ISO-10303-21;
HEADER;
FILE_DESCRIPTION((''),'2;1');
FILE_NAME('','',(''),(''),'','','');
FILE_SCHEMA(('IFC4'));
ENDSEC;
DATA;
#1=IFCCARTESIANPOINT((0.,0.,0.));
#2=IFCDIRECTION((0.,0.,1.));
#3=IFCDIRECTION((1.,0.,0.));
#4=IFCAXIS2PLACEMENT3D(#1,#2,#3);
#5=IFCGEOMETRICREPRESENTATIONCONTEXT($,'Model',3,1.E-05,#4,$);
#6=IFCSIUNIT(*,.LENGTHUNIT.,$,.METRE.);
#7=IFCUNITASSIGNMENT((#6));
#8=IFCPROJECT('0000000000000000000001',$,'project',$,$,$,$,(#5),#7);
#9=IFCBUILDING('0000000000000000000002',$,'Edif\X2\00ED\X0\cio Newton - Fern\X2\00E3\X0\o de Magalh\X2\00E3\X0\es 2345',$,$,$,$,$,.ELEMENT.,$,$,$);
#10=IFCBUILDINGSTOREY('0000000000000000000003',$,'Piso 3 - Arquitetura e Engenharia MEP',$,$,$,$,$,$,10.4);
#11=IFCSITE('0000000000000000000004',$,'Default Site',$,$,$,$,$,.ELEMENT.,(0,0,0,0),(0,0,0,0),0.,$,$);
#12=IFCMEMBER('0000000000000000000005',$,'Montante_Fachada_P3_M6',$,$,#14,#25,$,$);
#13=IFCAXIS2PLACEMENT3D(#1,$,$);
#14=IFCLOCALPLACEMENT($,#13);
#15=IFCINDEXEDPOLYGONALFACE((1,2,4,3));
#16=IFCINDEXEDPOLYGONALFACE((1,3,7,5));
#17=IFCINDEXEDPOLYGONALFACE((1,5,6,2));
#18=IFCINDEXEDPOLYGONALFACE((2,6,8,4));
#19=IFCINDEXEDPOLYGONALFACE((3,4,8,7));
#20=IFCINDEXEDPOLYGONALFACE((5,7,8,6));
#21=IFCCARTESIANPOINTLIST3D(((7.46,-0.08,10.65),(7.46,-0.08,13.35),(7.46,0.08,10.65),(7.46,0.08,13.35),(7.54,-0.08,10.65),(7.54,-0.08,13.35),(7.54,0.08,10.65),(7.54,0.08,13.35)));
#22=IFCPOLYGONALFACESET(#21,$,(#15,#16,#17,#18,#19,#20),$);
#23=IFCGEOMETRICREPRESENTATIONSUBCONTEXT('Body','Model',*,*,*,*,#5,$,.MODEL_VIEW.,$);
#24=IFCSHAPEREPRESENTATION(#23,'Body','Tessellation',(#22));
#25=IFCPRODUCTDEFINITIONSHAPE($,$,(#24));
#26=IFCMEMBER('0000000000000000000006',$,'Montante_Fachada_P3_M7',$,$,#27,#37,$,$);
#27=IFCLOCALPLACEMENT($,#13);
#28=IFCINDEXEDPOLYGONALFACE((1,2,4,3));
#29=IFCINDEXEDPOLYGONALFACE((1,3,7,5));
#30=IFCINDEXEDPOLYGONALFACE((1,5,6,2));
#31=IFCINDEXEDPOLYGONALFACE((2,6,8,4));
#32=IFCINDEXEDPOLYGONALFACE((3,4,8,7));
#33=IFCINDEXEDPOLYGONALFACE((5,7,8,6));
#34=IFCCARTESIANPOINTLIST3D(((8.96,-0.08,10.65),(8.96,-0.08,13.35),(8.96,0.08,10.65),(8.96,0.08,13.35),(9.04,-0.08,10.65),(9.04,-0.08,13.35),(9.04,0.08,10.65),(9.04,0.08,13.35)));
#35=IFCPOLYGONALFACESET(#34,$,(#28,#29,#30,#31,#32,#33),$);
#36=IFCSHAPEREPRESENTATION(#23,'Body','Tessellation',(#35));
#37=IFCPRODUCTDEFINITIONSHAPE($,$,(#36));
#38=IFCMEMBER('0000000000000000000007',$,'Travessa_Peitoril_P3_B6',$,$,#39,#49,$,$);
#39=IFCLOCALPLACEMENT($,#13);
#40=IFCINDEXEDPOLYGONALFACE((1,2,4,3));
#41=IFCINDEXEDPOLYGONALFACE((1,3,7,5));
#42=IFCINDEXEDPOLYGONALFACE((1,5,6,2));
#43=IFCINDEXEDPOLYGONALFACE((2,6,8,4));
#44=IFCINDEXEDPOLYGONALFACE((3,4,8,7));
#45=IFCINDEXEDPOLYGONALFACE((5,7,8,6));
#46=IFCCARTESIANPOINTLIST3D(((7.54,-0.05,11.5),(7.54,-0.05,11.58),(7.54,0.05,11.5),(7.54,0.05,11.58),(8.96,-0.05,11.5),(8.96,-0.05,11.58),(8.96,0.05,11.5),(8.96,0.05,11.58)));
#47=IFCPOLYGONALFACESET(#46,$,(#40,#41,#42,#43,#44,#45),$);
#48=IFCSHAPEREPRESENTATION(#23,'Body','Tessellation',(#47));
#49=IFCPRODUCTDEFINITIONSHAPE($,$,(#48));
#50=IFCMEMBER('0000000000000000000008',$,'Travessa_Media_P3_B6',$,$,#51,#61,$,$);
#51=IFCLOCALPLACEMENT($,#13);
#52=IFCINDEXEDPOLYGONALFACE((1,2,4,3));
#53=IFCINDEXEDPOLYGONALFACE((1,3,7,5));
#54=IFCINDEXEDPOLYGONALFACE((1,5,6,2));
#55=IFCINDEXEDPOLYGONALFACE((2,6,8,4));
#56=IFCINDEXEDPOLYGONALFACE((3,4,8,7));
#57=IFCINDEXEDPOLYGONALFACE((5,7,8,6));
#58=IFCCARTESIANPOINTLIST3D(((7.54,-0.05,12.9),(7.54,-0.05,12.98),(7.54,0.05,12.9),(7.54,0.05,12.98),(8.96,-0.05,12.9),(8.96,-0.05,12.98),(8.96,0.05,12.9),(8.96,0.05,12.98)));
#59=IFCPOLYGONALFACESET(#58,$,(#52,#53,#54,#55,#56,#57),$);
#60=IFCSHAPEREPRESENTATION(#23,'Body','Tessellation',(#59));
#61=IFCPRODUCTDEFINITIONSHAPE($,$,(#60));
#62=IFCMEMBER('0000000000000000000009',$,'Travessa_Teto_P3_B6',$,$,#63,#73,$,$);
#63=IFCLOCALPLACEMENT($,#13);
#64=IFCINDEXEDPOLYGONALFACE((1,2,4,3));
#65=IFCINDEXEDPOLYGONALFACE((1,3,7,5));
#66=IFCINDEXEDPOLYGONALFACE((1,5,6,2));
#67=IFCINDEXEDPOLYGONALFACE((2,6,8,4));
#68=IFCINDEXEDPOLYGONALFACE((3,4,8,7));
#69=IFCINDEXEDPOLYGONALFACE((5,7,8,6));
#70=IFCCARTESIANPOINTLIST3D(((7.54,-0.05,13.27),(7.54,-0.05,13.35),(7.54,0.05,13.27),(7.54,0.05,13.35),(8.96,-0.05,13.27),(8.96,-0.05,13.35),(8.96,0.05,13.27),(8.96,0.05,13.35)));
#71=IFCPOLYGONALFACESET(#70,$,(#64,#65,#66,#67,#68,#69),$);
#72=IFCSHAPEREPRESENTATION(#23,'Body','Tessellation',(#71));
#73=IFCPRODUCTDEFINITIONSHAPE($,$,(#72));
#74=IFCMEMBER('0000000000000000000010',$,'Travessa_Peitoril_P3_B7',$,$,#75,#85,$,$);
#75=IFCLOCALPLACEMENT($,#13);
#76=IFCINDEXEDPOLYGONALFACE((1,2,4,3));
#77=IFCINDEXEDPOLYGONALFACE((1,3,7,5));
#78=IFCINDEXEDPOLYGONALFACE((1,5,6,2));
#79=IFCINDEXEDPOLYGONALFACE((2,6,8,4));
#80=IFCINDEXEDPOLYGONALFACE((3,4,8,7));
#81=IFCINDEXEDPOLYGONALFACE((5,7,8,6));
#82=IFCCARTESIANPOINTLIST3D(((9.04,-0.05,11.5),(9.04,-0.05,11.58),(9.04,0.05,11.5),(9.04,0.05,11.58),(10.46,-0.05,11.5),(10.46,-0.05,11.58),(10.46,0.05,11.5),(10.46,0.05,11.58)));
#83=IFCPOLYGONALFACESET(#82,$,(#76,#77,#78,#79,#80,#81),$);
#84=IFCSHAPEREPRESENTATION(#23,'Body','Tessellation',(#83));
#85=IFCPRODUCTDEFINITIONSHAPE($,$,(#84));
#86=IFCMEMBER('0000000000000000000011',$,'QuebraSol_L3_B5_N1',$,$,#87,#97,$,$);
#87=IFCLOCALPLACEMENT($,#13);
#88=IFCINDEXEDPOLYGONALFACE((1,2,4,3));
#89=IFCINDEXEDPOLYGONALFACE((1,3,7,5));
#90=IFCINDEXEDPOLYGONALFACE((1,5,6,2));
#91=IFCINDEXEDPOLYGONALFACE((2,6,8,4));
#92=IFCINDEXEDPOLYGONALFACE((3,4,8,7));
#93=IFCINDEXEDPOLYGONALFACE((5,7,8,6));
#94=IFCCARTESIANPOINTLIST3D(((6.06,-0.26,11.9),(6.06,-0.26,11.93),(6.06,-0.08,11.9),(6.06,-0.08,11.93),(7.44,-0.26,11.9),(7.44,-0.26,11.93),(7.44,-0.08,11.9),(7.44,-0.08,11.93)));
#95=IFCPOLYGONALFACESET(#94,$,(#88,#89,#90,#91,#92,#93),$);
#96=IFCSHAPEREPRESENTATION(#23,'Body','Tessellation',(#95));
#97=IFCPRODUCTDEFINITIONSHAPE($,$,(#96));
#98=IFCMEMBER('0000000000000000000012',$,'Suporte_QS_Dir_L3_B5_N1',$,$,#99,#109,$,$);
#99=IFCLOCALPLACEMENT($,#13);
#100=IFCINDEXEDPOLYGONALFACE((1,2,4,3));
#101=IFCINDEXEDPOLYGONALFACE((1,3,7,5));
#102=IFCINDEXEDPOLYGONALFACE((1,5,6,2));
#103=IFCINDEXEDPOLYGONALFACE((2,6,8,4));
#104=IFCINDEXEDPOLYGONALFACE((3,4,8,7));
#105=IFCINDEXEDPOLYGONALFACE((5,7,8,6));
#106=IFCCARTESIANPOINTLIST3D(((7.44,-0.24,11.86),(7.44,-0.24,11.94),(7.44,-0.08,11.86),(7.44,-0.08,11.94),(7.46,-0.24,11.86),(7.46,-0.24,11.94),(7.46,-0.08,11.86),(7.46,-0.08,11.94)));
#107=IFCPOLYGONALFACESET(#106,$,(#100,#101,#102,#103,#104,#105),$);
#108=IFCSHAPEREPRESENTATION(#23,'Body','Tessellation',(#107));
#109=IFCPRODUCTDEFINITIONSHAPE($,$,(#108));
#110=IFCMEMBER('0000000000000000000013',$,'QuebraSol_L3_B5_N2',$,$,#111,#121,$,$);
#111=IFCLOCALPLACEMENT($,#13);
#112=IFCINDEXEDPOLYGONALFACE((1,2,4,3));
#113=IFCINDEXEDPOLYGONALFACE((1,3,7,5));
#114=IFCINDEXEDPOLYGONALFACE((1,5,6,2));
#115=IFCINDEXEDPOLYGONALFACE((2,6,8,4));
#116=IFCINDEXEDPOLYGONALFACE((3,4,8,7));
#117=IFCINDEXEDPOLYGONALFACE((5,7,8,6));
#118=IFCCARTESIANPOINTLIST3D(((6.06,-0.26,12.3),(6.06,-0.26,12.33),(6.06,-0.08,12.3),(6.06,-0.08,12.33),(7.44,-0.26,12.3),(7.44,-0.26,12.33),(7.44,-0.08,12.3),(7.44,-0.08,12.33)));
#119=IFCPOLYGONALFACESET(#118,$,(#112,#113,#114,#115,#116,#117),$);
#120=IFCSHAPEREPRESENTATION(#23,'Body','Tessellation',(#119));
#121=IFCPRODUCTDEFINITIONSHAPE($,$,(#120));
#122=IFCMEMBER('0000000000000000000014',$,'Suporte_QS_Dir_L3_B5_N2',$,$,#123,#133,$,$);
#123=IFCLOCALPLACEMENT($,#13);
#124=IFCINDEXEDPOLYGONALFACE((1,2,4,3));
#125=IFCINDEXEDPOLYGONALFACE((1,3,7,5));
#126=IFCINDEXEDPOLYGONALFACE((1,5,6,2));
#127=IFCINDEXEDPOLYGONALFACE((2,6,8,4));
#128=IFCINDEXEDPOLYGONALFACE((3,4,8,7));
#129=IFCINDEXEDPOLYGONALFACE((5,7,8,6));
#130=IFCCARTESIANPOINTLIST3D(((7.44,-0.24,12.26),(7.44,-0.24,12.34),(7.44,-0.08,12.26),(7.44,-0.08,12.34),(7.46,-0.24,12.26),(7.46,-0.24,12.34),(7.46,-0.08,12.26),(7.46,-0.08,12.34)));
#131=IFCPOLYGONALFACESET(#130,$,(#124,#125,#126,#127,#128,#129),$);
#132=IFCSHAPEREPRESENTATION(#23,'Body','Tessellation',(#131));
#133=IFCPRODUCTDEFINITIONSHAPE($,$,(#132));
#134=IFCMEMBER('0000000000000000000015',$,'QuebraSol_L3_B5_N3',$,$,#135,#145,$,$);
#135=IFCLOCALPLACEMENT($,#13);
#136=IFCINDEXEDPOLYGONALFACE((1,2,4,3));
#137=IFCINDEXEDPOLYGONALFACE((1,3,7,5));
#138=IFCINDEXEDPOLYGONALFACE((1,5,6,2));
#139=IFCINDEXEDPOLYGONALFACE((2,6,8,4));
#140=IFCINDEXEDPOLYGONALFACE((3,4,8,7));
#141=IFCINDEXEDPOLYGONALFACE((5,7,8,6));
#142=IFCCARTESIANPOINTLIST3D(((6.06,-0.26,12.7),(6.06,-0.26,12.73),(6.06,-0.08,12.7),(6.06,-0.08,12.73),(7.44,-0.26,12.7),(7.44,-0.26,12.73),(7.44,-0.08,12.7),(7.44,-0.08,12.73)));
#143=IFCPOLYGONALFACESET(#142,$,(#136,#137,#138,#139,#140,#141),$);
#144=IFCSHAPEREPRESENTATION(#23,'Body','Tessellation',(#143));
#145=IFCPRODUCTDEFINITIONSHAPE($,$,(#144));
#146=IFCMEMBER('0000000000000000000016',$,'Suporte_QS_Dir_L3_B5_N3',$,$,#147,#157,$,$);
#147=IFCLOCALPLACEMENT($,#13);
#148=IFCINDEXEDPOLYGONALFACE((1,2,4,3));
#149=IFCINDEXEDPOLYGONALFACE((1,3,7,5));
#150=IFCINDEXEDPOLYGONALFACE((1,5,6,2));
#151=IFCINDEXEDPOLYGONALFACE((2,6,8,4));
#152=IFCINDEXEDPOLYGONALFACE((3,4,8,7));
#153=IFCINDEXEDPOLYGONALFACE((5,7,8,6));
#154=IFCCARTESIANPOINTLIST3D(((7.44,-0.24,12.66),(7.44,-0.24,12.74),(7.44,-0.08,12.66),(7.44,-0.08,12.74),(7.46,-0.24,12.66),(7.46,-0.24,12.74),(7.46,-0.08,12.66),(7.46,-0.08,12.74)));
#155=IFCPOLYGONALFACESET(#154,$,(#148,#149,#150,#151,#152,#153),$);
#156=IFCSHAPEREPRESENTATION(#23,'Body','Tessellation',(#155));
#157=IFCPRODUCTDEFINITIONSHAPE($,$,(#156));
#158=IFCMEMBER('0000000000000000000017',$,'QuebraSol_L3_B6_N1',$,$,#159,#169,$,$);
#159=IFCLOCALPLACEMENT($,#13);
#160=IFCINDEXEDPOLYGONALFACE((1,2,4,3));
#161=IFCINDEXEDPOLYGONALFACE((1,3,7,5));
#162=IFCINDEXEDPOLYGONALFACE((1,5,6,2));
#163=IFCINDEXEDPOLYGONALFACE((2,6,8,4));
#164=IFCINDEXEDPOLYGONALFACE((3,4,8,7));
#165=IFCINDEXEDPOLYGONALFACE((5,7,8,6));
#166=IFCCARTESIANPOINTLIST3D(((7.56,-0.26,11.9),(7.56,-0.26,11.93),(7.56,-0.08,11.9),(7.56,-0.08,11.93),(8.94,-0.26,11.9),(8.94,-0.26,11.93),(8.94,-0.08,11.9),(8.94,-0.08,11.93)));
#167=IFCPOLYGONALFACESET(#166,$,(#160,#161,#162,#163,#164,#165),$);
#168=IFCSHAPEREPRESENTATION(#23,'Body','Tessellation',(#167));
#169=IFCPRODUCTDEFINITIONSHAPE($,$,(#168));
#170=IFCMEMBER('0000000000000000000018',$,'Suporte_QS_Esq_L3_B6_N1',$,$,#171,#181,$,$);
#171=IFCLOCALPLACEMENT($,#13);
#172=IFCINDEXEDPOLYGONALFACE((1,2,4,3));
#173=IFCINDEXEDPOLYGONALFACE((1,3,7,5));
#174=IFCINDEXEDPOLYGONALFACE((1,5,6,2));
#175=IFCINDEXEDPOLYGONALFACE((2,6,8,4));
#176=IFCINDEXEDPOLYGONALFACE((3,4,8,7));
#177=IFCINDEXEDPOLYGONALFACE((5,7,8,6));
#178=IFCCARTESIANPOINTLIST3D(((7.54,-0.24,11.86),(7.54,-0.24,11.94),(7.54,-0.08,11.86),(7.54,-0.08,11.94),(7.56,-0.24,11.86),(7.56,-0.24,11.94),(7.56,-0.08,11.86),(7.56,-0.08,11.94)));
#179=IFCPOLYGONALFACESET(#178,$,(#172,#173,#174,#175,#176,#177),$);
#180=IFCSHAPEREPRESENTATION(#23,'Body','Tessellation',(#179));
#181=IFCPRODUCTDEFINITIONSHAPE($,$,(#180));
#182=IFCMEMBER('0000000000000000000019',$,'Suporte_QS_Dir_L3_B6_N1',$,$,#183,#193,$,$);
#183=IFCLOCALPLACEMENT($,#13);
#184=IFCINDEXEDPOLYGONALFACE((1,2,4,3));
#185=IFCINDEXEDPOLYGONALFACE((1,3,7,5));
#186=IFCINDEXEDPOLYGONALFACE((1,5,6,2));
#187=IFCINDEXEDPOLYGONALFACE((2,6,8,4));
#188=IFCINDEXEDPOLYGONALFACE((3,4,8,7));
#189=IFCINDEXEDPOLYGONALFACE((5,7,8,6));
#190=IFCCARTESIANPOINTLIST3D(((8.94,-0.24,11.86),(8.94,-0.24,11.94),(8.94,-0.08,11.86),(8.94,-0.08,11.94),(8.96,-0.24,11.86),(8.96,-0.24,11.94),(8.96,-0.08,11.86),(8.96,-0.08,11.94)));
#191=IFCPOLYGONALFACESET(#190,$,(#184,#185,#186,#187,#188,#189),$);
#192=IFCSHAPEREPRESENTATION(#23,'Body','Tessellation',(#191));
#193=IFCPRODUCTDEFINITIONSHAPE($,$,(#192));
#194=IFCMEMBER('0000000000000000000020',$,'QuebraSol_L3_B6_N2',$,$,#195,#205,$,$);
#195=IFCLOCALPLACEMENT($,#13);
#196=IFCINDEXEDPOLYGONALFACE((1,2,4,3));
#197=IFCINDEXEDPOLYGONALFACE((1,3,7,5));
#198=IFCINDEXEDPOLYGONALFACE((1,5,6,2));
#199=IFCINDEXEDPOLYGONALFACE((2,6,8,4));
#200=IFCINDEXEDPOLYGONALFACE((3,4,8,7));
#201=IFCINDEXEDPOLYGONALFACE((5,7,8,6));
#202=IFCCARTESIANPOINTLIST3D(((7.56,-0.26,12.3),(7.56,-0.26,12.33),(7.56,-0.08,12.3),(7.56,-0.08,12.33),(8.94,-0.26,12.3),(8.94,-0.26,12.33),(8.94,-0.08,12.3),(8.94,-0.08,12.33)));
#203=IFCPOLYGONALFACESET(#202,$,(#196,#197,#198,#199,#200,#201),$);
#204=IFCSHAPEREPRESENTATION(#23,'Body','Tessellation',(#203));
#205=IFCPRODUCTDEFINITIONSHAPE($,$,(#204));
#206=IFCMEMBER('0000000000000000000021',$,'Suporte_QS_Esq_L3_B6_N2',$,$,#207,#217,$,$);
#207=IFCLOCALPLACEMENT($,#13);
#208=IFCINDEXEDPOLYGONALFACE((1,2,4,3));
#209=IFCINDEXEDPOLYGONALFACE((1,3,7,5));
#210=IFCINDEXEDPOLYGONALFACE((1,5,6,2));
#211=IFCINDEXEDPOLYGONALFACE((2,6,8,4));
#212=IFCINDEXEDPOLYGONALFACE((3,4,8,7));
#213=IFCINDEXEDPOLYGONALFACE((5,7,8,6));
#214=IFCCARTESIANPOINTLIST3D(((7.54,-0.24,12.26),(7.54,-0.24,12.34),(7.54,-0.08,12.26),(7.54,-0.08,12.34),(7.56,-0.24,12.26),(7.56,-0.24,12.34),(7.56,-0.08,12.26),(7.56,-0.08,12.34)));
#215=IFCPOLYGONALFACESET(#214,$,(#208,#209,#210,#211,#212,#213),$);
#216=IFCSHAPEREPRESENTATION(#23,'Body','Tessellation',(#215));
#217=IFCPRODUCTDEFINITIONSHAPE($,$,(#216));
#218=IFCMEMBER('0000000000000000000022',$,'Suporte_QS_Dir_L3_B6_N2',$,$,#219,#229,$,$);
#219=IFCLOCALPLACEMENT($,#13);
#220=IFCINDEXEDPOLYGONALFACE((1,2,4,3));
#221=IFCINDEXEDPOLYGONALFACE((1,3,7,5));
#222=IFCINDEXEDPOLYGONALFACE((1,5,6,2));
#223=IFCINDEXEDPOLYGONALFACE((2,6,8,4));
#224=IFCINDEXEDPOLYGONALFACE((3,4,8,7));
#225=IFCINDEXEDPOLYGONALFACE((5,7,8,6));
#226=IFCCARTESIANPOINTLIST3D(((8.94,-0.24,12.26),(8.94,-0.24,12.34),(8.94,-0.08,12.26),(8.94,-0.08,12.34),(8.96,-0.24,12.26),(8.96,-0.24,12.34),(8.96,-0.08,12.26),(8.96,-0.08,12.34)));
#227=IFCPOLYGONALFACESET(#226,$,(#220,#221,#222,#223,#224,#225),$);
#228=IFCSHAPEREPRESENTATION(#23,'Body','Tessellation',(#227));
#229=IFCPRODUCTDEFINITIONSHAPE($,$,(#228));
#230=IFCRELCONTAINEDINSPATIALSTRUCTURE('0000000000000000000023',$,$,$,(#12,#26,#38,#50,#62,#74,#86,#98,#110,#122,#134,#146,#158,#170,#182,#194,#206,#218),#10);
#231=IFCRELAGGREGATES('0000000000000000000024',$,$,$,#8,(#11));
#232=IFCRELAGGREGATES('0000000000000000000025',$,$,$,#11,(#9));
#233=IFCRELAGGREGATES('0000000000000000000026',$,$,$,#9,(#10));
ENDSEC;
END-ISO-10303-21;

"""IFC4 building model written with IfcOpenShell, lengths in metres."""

from ifc_helpers import new_model, si_unit, frame, frame_2d, origin_with_axes, place, context, subcontext, project, spatial, rectangle, extrude, element, save


model = new_model("IFC4")

# Units and contexts
model_context = context("Model", 3, precision=1e-05, world=origin_with_axes())
body_context = subcontext(model_context, "Body", "Model", "MODEL_VIEW")
ifc_project = project(units=[si_unit("LENGTHUNIT", "METRE")], contexts=[model_context])

# Site, building, storey
site = spatial("IfcSite", under=ifc_project, Name="Default Site", CompositionType="ELEMENT", RefLatitude=(0, 0, 0, 0), RefLongitude=(0, 0, 0, 0), RefElevation=0.0)
building = spatial("IfcBuilding", under=site, Name="Edifício Newton - Fernão de Magalhães 2345", CompositionType="ELEMENT")
storey = spatial("IfcBuildingStorey", under=building, Name="Piso 3 - Arquitetura e Engenharia MEP", Elevation=10.4)

# Members
for number, where, z_axis, x_axis, name in (
    (1, (7.46, -0.08, 10.65), (0.0, 0.0, 1.0), (1.0, 0.0, 0.0), "Montante_Fachada_P3_M6"),
    (2, (8.96, -0.08, 10.65), (0.0, 0.0, 1.0), (1.0, 0.0, 0.0), "Montante_Fachada_P3_M7"),
):
    element("IfcMember", number, at=place(None, frame(where, z_axis=z_axis, x_axis=x_axis)), inside=storey, Name=name, context=body_context, shape_type="SweptSolid", body=[
        extrude(rectangle(XDim=0.08, YDim=0.16, at=frame_2d((0.04, 0.08))), origin_with_axes(), (0.0, 0.0, 1.0), 2.7),
    ])
for number, where, z_axis, x_axis, name in (
    (3, (7.54, -0.05, 11.5), (0.0, 0.0, 1.0), (1.0, 0.0, 0.0), "Travessa_Peitoril_P3_B6"),
    (4, (7.54, -0.05, 12.9), (0.0, 0.0, 1.0), (1.0, 0.0, 0.0), "Travessa_Media_P3_B6"),
    (5, (7.54, -0.05, 13.27), (0.0, 0.0, 1.0), (1.0, 0.0, 0.0), "Travessa_Teto_P3_B6"),
):
    element("IfcMember", number, at=place(None, frame(where, z_axis=z_axis, x_axis=x_axis)), inside=storey, Name=name, context=body_context, shape_type="SweptSolid", body=[
        extrude(rectangle(XDim=1.42, YDim=0.1, at=frame_2d((0.71, 0.05))), origin_with_axes(), (0.0, 0.0, 1.0), 0.08),
    ])
member_1_placement = place(None, frame((9.04, -0.05, 11.5), z_axis=(0.0, 0.0, 1.0), x_axis=(1.0, 0.0, 0.0)))
element("IfcMember", 6, at=member_1_placement, inside=storey, Name="Travessa_Peitoril_P3_B7", context=body_context, shape_type="SweptSolid", body=[
    extrude(rectangle(XDim=1.42, YDim=0.1, at=frame_2d((0.71, 0.05))), origin_with_axes(), (0.0, 0.0, 1.0), 0.08),
])
member_2_placement = place(None, frame((6.06, -0.26, 11.9), z_axis=(0.0, 0.0, 1.0), x_axis=(1.0, 0.0, 0.0)))
element("IfcMember", 7, at=member_2_placement, inside=storey, Name="QuebraSol_L3_B5_N1", context=body_context, shape_type="SweptSolid", body=[
    extrude(rectangle(XDim=1.38, YDim=0.18, at=frame_2d((0.69, 0.09))), origin_with_axes(), (0.0, 0.0, 1.0), 0.03),
])
member_3_placement = place(None, frame((7.44, -0.24, 11.86), z_axis=(0.0, 0.0, 1.0), x_axis=(1.0, 0.0, 0.0)))
element("IfcMember", 8, at=member_3_placement, inside=storey, Name="Suporte_QS_Dir_L3_B5_N1", context=body_context, shape_type="SweptSolid", body=[
    extrude(rectangle(XDim=0.02, YDim=0.16, at=frame_2d((0.01, 0.08))), origin_with_axes(), (0.0, 0.0, 1.0), 0.08),
])
member_4_placement = place(None, frame((6.06, -0.26, 12.3), z_axis=(0.0, 0.0, 1.0), x_axis=(1.0, 0.0, 0.0)))
element("IfcMember", 9, at=member_4_placement, inside=storey, Name="QuebraSol_L3_B5_N2", context=body_context, shape_type="SweptSolid", body=[
    extrude(rectangle(XDim=1.38, YDim=0.18, at=frame_2d((0.69, 0.09))), origin_with_axes(), (0.0, 0.0, 1.0), 0.03),
])
member_5_placement = place(None, frame((7.44, -0.24, 12.26), z_axis=(0.0, 0.0, 1.0), x_axis=(1.0, 0.0, 0.0)))
element("IfcMember", 10, at=member_5_placement, inside=storey, Name="Suporte_QS_Dir_L3_B5_N2", context=body_context, shape_type="SweptSolid", body=[
    extrude(rectangle(XDim=0.02, YDim=0.16, at=frame_2d((0.01, 0.08))), origin_with_axes(), (0.0, 0.0, 1.0), 0.08),
])
member_6_placement = place(None, frame((6.06, -0.26, 12.7), z_axis=(0.0, 0.0, 1.0), x_axis=(1.0, 0.0, 0.0)))
element("IfcMember", 11, at=member_6_placement, inside=storey, Name="QuebraSol_L3_B5_N3", context=body_context, shape_type="SweptSolid", body=[
    extrude(rectangle(XDim=1.38, YDim=0.18, at=frame_2d((0.69, 0.09))), origin_with_axes(), (0.0, 0.0, 1.0), 0.03),
])
member_7_placement = place(None, frame((7.44, -0.24, 12.66), z_axis=(0.0, 0.0, 1.0), x_axis=(1.0, 0.0, 0.0)))
element("IfcMember", 12, at=member_7_placement, inside=storey, Name="Suporte_QS_Dir_L3_B5_N3", context=body_context, shape_type="SweptSolid", body=[
    extrude(rectangle(XDim=0.02, YDim=0.16, at=frame_2d((0.01, 0.08))), origin_with_axes(), (0.0, 0.0, 1.0), 0.08),
])
member_8_placement = place(None, frame((7.56, -0.26, 11.9), z_axis=(0.0, 0.0, 1.0), x_axis=(1.0, 0.0, 0.0)))
element("IfcMember", 13, at=member_8_placement, inside=storey, Name="QuebraSol_L3_B6_N1", context=body_context, shape_type="SweptSolid", body=[
    extrude(rectangle(XDim=1.38, YDim=0.18, at=frame_2d((0.69, 0.09))), origin_with_axes(), (0.0, 0.0, 1.0), 0.03),
])
for number, where, z_axis, x_axis, name in (
    (14, (7.54, -0.24, 11.86), (0.0, 0.0, 1.0), (1.0, 0.0, 0.0), "Suporte_QS_Esq_L3_B6_N1"),
    (15, (8.94, -0.24, 11.86), (0.0, 0.0, 1.0), (1.0, 0.0, 0.0), "Suporte_QS_Dir_L3_B6_N1"),
):
    element("IfcMember", number, at=place(None, frame(where, z_axis=z_axis, x_axis=x_axis)), inside=storey, Name=name, context=body_context, shape_type="SweptSolid", body=[
        extrude(rectangle(XDim=0.02, YDim=0.16, at=frame_2d((0.01, 0.08))), origin_with_axes(), (0.0, 0.0, 1.0), 0.08),
    ])
member_9_placement = place(None, frame((7.56, -0.26, 12.3), z_axis=(0.0, 0.0, 1.0), x_axis=(1.0, 0.0, 0.0)))
element("IfcMember", 16, at=member_9_placement, inside=storey, Name="QuebraSol_L3_B6_N2", context=body_context, shape_type="SweptSolid", body=[
    extrude(rectangle(XDim=1.38, YDim=0.18, at=frame_2d((0.69, 0.09))), origin_with_axes(), (0.0, 0.0, 1.0), 0.03),
])
for number, where, z_axis, x_axis, name in (
    (17, (7.54, -0.24, 12.26), (0.0, 0.0, 1.0), (1.0, 0.0, 0.0), "Suporte_QS_Esq_L3_B6_N2"),
    (18, (8.94, -0.24, 12.26), (0.0, 0.0, 1.0), (1.0, 0.0, 0.0), "Suporte_QS_Dir_L3_B6_N2"),
):
    element("IfcMember", number, at=place(None, frame(where, z_axis=z_axis, x_axis=x_axis)), inside=storey, Name=name, context=body_context, shape_type="SweptSolid", body=[
        extrude(rectangle(XDim=0.02, YDim=0.16, at=frame_2d((0.01, 0.08))), origin_with_axes(), (0.0, 0.0, 1.0), 0.08),
    ])

save(model, "model.ifc")
